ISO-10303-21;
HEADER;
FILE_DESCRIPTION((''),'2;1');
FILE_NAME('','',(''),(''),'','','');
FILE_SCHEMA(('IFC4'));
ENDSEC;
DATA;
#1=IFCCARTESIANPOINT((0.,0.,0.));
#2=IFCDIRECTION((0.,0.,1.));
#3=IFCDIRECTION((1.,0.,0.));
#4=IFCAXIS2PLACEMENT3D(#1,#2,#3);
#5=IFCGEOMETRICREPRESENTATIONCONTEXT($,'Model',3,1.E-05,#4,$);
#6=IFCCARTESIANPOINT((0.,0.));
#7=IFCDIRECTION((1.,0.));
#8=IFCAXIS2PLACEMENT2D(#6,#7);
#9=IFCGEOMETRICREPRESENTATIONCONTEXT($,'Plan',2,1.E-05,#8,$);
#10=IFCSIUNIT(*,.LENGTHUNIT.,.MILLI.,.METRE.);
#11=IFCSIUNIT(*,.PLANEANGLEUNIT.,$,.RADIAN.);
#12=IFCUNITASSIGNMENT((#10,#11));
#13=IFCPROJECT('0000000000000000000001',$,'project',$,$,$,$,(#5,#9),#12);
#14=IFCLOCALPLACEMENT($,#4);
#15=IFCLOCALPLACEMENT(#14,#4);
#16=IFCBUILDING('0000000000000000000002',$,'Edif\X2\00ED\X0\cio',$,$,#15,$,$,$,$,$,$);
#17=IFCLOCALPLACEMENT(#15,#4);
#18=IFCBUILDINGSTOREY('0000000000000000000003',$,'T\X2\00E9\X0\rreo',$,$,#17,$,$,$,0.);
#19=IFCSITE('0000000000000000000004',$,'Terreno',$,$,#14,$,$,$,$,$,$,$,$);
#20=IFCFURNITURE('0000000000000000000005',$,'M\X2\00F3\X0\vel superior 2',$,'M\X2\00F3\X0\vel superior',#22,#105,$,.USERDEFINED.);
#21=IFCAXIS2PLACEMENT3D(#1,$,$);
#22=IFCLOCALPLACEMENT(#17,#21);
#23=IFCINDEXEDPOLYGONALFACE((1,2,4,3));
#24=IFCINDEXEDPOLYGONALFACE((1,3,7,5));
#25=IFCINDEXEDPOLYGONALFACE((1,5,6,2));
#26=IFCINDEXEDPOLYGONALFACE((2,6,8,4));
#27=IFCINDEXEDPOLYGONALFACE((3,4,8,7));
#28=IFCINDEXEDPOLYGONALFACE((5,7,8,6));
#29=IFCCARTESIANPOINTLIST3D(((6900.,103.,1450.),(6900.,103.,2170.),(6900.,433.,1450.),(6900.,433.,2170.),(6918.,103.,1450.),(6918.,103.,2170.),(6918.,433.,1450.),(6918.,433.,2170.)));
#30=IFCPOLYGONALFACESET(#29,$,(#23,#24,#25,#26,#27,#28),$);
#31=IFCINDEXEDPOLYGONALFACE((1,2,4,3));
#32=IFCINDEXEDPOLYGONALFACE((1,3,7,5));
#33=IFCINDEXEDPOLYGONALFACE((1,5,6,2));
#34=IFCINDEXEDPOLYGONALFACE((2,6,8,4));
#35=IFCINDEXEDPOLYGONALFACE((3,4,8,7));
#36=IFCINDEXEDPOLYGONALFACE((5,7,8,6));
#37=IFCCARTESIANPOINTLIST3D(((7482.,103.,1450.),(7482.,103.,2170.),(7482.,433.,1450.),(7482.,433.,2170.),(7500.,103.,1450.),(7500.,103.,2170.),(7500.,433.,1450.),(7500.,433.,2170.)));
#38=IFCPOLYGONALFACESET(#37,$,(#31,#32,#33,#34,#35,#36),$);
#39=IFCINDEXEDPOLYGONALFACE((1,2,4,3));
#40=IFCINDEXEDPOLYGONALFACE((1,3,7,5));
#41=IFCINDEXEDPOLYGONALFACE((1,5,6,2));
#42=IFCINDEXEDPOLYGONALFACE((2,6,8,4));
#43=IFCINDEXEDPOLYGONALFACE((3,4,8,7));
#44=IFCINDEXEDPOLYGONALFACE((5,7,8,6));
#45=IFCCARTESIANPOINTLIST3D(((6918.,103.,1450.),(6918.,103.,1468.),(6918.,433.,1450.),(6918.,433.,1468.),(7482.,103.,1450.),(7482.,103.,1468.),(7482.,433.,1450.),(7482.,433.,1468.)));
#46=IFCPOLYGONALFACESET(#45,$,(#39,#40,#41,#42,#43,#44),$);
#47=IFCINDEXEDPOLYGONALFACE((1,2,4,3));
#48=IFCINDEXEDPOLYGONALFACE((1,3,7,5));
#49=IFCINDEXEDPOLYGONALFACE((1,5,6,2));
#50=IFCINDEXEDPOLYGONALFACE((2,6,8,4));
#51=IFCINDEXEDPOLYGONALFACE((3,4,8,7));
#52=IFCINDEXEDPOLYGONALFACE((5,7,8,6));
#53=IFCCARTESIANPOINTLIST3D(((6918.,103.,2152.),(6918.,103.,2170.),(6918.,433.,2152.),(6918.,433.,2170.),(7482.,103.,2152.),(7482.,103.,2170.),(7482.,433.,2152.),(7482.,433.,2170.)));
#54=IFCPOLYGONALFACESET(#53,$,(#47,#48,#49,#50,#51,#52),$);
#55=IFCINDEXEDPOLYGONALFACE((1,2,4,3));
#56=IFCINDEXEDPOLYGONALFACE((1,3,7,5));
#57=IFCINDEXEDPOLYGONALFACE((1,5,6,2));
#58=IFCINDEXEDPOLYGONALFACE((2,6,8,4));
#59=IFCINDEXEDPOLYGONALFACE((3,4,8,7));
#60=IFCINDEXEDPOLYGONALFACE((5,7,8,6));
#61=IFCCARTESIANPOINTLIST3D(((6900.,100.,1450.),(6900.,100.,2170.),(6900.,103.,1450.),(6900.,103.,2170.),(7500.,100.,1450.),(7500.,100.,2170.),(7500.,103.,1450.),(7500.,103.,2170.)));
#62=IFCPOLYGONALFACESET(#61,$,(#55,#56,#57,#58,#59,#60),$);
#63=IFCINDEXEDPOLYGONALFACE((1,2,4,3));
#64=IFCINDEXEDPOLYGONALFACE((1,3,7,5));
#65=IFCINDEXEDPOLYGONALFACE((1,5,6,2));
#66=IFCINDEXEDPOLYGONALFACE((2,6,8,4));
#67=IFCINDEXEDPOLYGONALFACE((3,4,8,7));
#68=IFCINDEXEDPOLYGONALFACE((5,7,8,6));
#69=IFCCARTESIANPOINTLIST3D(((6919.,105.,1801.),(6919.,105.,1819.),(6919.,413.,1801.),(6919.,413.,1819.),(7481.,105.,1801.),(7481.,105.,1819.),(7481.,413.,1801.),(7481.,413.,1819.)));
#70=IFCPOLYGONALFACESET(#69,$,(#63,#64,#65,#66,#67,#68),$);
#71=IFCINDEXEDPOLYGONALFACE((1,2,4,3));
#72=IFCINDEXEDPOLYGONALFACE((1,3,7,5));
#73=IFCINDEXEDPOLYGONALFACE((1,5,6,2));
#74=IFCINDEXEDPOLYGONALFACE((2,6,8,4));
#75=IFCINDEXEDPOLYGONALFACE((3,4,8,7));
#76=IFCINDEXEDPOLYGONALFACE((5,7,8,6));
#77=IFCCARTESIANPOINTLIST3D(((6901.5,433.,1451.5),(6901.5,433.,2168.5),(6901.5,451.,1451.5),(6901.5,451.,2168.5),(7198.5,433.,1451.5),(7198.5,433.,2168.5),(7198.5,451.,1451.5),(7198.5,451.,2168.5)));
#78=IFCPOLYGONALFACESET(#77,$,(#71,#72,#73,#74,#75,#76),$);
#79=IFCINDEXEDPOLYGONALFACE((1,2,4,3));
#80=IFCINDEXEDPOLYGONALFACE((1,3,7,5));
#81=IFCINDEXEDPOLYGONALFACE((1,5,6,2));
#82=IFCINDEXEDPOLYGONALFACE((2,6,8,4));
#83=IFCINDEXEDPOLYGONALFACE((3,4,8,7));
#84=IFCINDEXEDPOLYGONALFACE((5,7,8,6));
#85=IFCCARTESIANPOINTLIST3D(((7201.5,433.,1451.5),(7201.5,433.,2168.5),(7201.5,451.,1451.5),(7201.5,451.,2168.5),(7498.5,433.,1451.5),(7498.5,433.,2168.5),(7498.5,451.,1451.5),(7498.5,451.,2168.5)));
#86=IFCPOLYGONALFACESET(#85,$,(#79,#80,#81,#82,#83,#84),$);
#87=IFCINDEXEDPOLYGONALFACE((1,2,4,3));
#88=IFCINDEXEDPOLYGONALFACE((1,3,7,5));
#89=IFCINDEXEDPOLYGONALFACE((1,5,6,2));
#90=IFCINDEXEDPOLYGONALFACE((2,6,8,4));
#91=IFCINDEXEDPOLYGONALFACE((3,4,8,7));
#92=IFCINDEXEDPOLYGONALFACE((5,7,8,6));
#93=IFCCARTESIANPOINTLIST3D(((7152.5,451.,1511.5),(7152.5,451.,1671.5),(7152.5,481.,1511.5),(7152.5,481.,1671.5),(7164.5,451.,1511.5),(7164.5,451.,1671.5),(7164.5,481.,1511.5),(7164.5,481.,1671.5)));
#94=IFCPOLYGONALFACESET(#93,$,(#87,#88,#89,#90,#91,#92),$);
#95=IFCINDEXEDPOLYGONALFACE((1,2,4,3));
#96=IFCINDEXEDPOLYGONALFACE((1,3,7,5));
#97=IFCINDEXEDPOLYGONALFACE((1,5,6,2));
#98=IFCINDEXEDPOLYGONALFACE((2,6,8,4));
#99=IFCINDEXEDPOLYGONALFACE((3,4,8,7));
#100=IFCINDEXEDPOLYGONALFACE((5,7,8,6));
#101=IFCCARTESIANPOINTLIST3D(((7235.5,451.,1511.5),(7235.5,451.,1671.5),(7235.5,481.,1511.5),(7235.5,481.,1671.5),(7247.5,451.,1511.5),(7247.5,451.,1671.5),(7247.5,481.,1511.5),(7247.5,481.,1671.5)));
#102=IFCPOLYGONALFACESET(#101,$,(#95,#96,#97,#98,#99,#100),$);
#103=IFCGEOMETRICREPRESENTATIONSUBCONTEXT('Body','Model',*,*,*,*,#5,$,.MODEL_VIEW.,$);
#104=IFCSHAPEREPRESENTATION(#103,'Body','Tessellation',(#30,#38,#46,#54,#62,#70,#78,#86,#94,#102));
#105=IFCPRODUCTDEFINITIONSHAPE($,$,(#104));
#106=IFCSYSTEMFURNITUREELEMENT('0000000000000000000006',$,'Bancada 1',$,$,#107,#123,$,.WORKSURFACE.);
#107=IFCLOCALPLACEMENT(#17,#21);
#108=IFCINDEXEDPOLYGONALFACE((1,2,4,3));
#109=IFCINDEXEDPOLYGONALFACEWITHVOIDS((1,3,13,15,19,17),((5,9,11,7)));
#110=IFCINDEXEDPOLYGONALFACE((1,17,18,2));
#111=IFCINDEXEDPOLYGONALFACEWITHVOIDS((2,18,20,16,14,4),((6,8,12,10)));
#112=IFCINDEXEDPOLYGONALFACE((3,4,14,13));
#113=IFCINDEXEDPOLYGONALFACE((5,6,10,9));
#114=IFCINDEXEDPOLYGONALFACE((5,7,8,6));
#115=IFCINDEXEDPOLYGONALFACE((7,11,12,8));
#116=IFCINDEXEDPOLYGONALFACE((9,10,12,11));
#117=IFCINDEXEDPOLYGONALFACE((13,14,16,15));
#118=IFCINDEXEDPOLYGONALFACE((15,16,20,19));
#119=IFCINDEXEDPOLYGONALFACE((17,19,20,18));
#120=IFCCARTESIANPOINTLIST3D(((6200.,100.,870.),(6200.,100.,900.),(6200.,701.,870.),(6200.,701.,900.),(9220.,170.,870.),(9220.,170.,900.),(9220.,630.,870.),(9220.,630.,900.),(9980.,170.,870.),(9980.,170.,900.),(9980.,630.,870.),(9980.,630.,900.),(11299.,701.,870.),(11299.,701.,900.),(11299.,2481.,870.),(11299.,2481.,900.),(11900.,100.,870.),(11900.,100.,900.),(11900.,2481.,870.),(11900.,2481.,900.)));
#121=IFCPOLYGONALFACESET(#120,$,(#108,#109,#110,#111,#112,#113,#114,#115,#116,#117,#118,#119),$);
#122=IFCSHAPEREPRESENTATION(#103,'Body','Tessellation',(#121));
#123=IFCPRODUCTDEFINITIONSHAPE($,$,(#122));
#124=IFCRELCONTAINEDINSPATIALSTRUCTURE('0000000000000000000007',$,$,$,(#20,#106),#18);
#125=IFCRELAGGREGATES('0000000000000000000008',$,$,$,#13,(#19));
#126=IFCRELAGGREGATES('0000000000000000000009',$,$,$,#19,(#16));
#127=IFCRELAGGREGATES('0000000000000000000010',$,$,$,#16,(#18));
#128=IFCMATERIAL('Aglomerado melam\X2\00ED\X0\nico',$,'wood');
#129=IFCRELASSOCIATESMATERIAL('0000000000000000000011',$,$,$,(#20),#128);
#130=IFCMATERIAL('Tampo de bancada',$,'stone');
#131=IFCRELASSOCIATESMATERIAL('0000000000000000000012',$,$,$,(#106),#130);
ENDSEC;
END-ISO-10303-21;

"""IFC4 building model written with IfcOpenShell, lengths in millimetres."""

from ifc_helpers import new_model, si_unit, frame, frame_2d, origin, origin_with_axes, origin_2d_with_axis, place, context, subcontext, project, spatial, indexed_curve, rectangle, outline, extrude, material, element, save


model = new_model("IFC4")

# Units and contexts
model_context = context("Model", 3, precision=1e-05, world=origin_with_axes())
plan_context = context("Plan", 2, precision=1e-05, world=origin_2d_with_axis())
body_context = subcontext(model_context, "Body", "Model", "MODEL_VIEW")
ifc_project = project(units=[si_unit("LENGTHUNIT", "METRE", prefix="MILLI"), si_unit("PLANEANGLEUNIT", "RADIAN")], contexts=[model_context, plan_context])

# Site, building, storey
site_placement = place(None, origin_with_axes())
site = spatial("IfcSite", under=ifc_project, at=site_placement, Name="Terreno")
building_placement = place(site_placement, origin_with_axes())
building = spatial("IfcBuilding", under=site, at=building_placement, Name="Edifício")
storey_placement = place(building_placement, origin_with_axes())
storey = spatial("IfcBuildingStorey", under=building, at=storey_placement, Name="Térreo", Elevation=0.0)

# Furniture
ifc_material_1 = material(Name="Aglomerado melamínico", Category="wood")
for number, where, z_axis, x_axis, name in (
    (1, (6900.0, 100.0, 0.0), (0.0, 0.0, 1.0), (1.0, 0.0, 0.0), "Móvel superior 2"),
):
    element("IfcFurniture", number, at=place(storey_placement, frame(where, z_axis=z_axis, x_axis=x_axis)), inside=storey, material=ifc_material_1, Name=name, ObjectType="Móvel superior", PredefinedType="USERDEFINED", context=body_context, shape_type="SweptSolid", body=[
        extrude(rectangle(XDim=18.0, YDim=330.0, at=frame_2d((9.0, 168.0))), frame((0.0, 0.0, 1450.0)), (0.0, 0.0, 1.0), 720.0),
        extrude(rectangle(XDim=18.0, YDim=330.0, at=frame_2d((591.0, 168.0))), frame((0.0, 0.0, 1450.0)), (0.0, 0.0, 1.0), 720.0),
        extrude(rectangle(XDim=564.0, YDim=330.0, at=frame_2d((300.0, 168.0))), frame((0.0, 0.0, 1450.0)), (0.0, 0.0, 1.0), 18.0),
        extrude(rectangle(XDim=564.0, YDim=330.0, at=frame_2d((300.0, 168.0))), frame((0.0, 0.0, 2152.0)), (0.0, 0.0, 1.0), 18.0),
        extrude(rectangle(XDim=600.0, YDim=3.0, at=frame_2d((300.0, 1.5))), frame((0.0, 0.0, 1450.0)), (0.0, 0.0, 1.0), 720.0),
        extrude(rectangle(XDim=562.0, YDim=308.0, at=frame_2d((300.0, 159.0))), frame((0.0, 0.0, 1801.0)), (0.0, 0.0, 1.0), 18.0),
        extrude(rectangle(XDim=297.0, YDim=18.0, at=frame_2d((150.0, 342.0))), frame((0.0, 0.0, 1451.5)), (0.0, 0.0, 1.0), 717.0),
        extrude(rectangle(XDim=297.0, YDim=18.0, at=frame_2d((450.0, 342.0))), frame((0.0, 0.0, 1451.5)), (0.0, 0.0, 1.0), 717.0),
        extrude(rectangle(XDim=12.0, YDim=30.0, at=frame_2d((258.5, 366.0))), frame((0.0, 0.0, 1511.5)), (0.0, 0.0, 1.0), 160.0),
        extrude(rectangle(XDim=12.0, YDim=30.0, at=frame_2d((341.5, 366.0))), frame((0.0, 0.0, 1511.5)), (0.0, 0.0, 1.0), 160.0),
    ])

# System furniture element
ifc_material_2 = material(Name="Tampo de bancada", Category="stone")
system_furniture_element_placement = place(storey_placement, frame((6200.0, 701.0, 870.0), z_axis=(0.0, 0.0, 1.0), x_axis=(1.0, 0.0, 0.0)))
element("IfcSystemFurnitureElement", 2, at=system_furniture_element_placement, inside=storey, material=ifc_material_2, Name="Bancada 1", PredefinedType="WORKSURFACE", context=body_context, shape_type="SweptSolid", body=[
    extrude(outline(indexed_curve([(0.0, 0.0), (5099.0, 0.0), (5099.0, 1780.0), (5700.0, 1780.0), (5700.0, -601.0), (0.0, -601.0), (0.0, 0.0)], self_intersect=False), holes=[indexed_curve([(3020.0, -531.0), (3780.0, -531.0), (3780.0, -71.0), (3020.0, -71.0), (3020.0, -531.0)], self_intersect=False)]), origin(), (0.0, 0.0, 1.0), 30.0),
])

save(model, "model.ifc")
